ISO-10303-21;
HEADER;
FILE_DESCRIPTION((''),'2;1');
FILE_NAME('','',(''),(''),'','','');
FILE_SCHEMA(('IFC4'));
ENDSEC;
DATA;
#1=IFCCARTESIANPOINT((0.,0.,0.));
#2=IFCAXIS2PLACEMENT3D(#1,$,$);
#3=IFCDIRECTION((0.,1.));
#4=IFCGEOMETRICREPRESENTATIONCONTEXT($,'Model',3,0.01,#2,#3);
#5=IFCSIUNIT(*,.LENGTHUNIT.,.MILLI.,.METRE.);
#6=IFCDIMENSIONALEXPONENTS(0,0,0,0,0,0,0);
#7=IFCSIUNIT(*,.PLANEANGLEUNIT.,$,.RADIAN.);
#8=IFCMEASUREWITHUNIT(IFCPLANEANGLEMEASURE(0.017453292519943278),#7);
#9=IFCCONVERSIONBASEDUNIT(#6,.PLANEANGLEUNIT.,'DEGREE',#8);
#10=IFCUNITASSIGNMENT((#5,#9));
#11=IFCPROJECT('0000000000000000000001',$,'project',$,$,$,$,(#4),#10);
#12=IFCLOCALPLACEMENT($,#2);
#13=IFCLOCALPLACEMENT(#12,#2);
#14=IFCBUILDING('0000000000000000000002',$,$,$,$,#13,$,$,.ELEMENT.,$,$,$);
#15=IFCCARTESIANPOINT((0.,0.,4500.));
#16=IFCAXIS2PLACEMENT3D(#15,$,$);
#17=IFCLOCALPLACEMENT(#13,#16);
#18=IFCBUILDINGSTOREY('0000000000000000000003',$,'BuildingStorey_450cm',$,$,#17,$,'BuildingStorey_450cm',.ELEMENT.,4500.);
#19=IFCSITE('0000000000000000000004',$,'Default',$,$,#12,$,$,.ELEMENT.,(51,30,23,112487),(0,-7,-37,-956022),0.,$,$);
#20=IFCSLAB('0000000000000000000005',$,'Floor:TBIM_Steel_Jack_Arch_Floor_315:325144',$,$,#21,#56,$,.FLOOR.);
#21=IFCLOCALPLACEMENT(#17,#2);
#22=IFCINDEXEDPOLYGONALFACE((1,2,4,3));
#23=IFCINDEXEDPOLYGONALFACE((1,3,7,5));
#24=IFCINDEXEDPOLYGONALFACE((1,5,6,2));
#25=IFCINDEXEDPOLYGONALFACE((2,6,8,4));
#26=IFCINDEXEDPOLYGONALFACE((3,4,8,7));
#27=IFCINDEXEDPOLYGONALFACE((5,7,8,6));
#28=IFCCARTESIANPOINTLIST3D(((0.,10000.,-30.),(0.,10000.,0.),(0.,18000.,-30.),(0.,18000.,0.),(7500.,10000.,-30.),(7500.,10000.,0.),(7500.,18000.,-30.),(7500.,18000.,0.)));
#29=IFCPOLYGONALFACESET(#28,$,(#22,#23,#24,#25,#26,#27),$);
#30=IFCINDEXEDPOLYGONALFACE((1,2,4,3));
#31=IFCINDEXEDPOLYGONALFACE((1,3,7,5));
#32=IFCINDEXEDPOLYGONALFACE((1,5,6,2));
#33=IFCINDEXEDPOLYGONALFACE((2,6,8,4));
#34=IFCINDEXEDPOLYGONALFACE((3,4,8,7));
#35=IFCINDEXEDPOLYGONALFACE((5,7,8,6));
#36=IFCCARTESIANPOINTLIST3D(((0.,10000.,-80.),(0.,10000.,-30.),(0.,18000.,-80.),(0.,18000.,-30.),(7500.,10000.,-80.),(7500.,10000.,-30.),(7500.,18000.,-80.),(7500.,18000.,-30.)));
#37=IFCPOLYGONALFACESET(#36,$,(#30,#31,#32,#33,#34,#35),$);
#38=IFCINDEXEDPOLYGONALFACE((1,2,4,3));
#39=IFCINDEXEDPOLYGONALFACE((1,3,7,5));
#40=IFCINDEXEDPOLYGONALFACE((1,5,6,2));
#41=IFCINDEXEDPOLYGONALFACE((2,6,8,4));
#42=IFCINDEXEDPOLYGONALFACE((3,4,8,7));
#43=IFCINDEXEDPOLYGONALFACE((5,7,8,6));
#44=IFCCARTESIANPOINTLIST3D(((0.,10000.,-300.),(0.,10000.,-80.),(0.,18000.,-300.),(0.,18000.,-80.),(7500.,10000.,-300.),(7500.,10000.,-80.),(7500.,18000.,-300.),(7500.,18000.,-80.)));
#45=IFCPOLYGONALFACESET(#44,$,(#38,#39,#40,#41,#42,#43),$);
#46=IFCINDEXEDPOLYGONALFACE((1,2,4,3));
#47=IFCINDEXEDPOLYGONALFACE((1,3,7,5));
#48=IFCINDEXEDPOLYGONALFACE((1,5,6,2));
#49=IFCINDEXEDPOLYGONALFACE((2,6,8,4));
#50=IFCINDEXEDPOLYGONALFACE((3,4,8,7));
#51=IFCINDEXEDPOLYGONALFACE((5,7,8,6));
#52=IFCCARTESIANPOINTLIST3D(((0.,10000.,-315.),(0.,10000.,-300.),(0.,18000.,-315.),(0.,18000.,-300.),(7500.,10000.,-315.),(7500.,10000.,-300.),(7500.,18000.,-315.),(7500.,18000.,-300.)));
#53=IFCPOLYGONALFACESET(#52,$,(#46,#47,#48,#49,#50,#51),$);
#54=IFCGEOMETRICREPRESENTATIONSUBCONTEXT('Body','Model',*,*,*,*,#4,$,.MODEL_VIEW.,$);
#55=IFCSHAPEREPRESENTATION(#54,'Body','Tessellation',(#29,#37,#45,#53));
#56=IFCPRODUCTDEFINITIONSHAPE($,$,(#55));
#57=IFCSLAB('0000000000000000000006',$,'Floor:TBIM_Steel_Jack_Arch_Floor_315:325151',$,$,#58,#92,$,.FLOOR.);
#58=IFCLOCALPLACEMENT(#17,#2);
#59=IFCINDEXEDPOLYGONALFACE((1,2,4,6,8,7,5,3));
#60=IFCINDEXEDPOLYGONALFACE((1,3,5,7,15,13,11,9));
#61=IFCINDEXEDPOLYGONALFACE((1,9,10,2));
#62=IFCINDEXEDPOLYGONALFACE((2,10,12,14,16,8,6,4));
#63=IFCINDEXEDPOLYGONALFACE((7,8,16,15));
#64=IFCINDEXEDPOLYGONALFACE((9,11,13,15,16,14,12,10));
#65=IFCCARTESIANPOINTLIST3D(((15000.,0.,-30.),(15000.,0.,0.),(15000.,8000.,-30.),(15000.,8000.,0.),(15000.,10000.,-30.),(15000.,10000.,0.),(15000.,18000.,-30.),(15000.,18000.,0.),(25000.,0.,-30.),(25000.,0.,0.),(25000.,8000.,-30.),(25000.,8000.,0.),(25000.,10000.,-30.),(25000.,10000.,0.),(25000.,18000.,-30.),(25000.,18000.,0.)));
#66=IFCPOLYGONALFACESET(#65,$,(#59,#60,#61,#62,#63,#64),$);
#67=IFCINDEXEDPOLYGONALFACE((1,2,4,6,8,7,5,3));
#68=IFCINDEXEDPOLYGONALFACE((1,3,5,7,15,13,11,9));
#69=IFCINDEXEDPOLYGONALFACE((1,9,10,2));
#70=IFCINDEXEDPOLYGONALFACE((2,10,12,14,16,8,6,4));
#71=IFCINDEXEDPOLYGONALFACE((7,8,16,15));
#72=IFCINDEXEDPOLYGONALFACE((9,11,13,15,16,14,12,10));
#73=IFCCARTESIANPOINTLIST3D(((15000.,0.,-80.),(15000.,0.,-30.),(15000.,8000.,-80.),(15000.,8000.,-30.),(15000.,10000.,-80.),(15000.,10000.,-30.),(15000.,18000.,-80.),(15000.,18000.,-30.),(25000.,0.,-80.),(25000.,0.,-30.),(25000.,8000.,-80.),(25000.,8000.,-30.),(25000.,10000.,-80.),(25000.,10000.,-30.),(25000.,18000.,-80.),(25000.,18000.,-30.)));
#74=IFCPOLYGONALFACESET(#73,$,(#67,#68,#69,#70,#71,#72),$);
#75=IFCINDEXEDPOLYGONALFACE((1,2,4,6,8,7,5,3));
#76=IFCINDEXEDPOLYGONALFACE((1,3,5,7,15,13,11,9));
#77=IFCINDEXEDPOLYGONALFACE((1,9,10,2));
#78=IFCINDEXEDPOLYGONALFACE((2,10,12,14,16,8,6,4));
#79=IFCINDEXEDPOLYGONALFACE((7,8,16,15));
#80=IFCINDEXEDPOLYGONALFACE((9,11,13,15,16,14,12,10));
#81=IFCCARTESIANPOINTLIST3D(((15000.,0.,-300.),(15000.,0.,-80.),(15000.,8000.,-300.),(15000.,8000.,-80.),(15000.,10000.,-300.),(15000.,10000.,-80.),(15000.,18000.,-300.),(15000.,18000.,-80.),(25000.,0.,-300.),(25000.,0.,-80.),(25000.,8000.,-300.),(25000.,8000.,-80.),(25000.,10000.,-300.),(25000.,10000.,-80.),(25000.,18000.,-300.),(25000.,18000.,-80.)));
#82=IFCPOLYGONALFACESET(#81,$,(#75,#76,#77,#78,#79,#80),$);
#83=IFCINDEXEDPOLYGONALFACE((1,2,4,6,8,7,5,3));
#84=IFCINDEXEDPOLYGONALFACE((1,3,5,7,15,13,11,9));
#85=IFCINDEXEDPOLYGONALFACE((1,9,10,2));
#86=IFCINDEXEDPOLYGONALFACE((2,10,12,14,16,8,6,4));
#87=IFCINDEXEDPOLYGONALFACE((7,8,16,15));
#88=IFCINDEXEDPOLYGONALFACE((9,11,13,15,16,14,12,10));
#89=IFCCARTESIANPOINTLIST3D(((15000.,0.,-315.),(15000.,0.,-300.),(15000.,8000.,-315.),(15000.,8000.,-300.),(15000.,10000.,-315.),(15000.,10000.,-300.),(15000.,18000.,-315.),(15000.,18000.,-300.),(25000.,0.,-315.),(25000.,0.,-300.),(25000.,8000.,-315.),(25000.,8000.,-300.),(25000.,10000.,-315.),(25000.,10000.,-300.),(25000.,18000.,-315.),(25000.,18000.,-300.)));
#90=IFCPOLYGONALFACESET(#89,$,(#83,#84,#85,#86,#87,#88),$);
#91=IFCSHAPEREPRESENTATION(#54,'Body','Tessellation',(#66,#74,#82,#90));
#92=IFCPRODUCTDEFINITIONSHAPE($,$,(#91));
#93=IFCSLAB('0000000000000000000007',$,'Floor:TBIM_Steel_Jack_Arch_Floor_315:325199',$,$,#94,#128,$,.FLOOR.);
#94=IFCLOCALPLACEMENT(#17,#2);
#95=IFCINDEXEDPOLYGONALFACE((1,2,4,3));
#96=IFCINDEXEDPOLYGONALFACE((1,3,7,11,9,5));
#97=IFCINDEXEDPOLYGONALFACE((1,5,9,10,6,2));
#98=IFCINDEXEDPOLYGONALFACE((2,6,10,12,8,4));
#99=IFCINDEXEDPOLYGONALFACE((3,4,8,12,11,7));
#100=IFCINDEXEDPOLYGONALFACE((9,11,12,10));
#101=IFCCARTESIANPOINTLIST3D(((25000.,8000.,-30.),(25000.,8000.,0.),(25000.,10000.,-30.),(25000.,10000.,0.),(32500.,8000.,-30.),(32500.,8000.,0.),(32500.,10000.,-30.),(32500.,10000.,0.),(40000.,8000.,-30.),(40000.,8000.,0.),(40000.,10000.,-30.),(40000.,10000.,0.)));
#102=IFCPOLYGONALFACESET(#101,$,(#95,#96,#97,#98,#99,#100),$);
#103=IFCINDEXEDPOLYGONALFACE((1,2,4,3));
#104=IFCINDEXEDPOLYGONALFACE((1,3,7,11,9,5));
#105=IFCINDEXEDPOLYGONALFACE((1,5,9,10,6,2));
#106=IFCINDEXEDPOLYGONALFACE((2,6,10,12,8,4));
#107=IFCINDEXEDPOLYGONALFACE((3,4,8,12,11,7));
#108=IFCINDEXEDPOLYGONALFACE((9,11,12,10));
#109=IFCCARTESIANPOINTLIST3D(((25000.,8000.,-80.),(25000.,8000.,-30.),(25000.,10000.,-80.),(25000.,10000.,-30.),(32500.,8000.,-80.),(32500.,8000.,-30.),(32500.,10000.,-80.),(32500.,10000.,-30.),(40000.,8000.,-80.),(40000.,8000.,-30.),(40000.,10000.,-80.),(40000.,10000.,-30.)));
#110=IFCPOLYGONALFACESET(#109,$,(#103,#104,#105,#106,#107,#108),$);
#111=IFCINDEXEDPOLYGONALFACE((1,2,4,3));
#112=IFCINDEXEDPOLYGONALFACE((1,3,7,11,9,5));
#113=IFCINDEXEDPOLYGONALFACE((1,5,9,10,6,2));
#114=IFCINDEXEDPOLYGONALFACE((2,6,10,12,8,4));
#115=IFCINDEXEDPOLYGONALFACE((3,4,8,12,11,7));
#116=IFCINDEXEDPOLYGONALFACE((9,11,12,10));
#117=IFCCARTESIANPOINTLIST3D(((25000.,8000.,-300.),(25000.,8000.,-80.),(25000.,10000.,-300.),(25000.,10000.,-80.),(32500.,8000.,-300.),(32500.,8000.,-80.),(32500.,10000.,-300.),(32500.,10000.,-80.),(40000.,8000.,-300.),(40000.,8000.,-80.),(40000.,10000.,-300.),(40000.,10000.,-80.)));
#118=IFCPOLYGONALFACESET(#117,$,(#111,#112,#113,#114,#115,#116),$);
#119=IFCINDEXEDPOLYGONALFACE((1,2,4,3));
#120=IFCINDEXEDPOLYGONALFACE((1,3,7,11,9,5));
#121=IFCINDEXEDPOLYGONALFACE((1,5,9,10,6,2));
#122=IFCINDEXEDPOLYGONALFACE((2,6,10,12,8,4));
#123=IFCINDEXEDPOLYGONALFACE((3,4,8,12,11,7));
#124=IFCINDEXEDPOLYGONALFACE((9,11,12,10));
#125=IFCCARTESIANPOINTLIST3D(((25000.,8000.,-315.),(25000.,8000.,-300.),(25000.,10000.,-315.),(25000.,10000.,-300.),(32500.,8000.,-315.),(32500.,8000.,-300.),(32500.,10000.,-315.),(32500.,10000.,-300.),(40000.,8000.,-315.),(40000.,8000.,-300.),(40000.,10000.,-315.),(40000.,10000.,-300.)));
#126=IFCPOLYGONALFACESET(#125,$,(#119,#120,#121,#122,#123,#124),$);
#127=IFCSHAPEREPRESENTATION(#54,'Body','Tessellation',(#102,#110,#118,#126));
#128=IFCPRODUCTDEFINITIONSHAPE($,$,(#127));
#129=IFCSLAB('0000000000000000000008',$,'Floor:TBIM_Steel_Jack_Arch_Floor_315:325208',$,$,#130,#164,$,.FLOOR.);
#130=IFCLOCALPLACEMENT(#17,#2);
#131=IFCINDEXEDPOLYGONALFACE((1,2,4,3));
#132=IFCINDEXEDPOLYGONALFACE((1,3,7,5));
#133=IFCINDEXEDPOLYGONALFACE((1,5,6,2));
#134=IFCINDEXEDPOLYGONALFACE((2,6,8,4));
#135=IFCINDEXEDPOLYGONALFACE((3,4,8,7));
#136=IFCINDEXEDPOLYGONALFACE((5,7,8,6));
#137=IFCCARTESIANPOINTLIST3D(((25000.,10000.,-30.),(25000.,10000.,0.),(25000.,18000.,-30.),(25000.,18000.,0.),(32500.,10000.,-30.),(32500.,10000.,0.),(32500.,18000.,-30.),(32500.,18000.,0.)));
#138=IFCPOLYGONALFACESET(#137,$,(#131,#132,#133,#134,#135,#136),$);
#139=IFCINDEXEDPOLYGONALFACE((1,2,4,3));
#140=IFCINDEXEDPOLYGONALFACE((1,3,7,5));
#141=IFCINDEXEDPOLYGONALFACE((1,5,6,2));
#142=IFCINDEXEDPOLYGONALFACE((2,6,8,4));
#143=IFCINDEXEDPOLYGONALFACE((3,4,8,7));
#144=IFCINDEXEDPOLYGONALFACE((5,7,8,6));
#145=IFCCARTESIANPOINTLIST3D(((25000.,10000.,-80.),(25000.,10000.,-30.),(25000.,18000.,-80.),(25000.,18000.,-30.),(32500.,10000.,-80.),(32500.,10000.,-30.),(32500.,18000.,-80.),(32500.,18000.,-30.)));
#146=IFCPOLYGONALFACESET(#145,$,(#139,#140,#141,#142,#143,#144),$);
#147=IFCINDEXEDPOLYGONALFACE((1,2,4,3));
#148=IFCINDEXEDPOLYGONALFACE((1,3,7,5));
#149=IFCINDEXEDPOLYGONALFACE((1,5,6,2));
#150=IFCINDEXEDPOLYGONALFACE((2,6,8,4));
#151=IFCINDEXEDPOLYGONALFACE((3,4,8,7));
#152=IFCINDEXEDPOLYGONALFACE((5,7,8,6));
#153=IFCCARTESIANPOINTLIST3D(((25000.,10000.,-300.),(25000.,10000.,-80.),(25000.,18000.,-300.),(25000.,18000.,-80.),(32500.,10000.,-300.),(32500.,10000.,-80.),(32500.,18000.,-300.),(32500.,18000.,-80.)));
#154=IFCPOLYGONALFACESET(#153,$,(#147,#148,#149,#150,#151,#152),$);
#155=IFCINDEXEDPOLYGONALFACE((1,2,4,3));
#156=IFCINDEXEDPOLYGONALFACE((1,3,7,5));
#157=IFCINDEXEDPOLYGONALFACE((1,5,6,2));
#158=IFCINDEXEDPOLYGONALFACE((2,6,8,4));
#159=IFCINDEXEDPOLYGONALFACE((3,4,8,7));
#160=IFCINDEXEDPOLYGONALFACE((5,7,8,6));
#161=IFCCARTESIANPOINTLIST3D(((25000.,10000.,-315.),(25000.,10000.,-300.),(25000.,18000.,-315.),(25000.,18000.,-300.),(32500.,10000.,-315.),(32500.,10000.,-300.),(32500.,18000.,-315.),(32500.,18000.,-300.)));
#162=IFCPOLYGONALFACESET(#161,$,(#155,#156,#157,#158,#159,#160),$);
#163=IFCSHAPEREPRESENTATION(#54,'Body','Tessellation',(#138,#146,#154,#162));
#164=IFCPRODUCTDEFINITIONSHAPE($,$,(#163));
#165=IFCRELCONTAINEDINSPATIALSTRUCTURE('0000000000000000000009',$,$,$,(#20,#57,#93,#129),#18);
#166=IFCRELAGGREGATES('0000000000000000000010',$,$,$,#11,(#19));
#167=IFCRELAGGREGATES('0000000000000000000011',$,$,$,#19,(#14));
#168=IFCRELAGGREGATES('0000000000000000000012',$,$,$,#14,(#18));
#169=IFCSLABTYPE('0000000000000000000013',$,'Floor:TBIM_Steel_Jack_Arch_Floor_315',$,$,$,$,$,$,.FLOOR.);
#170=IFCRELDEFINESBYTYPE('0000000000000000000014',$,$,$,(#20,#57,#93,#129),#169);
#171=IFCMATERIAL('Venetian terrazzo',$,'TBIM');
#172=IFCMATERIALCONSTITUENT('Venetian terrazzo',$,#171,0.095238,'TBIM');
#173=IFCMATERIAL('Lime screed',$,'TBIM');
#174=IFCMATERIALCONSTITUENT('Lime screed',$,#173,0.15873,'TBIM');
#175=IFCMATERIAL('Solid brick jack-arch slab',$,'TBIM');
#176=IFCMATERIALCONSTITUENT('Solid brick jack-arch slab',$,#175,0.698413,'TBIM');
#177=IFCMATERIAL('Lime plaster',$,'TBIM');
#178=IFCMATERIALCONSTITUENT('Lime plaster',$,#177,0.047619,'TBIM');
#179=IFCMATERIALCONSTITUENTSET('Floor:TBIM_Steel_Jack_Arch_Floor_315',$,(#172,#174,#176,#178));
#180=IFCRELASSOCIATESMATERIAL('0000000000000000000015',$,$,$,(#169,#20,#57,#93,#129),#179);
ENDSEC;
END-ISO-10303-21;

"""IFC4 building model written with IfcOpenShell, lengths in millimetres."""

from ifc_helpers import new_model, entity, si_unit, converted_unit, direction, frame, origin, place, context, subcontext, project, spatial, indexed_curve, outline, extrude, material, constituent, constituent_set, type_object, element, save


model = new_model("IFC4")

# Units and contexts
model_context = context("Model", 3, precision=0.01, world=origin(), true_north=direction((0.0, 1.0)))
body_context = subcontext(model_context, "Body", "Model", "MODEL_VIEW")
ifc_project = project(units=[si_unit("LENGTHUNIT", "METRE", prefix="MILLI"), converted_unit("PLANEANGLEUNIT", "DEGREE", entity("IfcPlaneAngleMeasure", 0.017453292519943278), si_unit("PLANEANGLEUNIT", "RADIAN"), dimensions=[0, 0, 0, 0, 0, 0, 0])], contexts=[model_context])

# Site, building, storey
site_placement = place(None, origin())
site = spatial("IfcSite", under=ifc_project, at=site_placement, Name="Default", CompositionType="ELEMENT", RefLatitude=(51, 30, 23, 112487), RefLongitude=(0, -7, -37, -956022), RefElevation=0.0)
building_placement = place(site_placement, origin())
building = spatial("IfcBuilding", under=site, at=building_placement, CompositionType="ELEMENT")
storey_placement = place(building_placement, frame((0.0, 0.0, 4500.0)))
storey = spatial("IfcBuildingStorey", under=building, at=storey_placement, Name="BuildingStorey_450cm", LongName="BuildingStorey_450cm", CompositionType="ELEMENT", Elevation=4500.0)

# Slabs
ifc_material_1 = material(Name="Venetian terrazzo", Category="TBIM")
ifc_constituent_1 = constituent(ifc_material_1, Name="Venetian terrazzo", Category="TBIM", fraction=0.095238)
ifc_material_2 = material(Name="Lime screed", Category="TBIM")
ifc_constituent_2 = constituent(ifc_material_2, Name="Lime screed", Category="TBIM", fraction=0.15873)
ifc_material_3 = material(Name="Solid brick jack-arch slab", Category="TBIM")
ifc_constituent_3 = constituent(ifc_material_3, Name="Solid brick jack-arch slab", Category="TBIM", fraction=0.698413)
ifc_material_4 = material(Name="Lime plaster", Category="TBIM")
ifc_constituent_4 = constituent(ifc_material_4, Name="Lime plaster", Category="TBIM", fraction=0.047619)
ifc_constituent_set_1 = constituent_set(constituents=[ifc_constituent_1, ifc_constituent_2, ifc_constituent_3, ifc_constituent_4], Name="Floor:TBIM_Steel_Jack_Arch_Floor_315")
slab_type = type_object("IfcSlabType", Name="Floor:TBIM_Steel_Jack_Arch_Floor_315", PredefinedType="FLOOR", material=ifc_constituent_set_1)
slab_1_placement = place(storey_placement, origin())
element("IfcSlab", 1, at=slab_1_placement, inside=storey, type_object=slab_type, material=ifc_constituent_set_1, Name="Floor:TBIM_Steel_Jack_Arch_Floor_315:325144", PredefinedType="FLOOR", context=body_context, shape_type="SweptSolid", body=[
    extrude(outline(indexed_curve([(-3750.0, -4000.0), (3750.0, -4000.0), (3750.0, 4000.0), (-3750.0, 4000.0), (-3750.0, -4000.0)], self_intersect=False)), frame((3750.0, 14000.0, -30.0), z_axis=(0.0, 0.0, 1.0), x_axis=(-1.0, 0.0, 0.0)), (0.0, 0.0, 1.0), 30.0),
    extrude(outline(indexed_curve([(-3750.0, -4000.0), (3750.0, -4000.0), (3750.0, 4000.0), (-3750.0, 4000.0), (-3750.0, -4000.0)], self_intersect=False)), frame((3750.0, 14000.0, -80.0), z_axis=(0.0, 0.0, 1.0), x_axis=(-1.0, 0.0, 0.0)), (0.0, 0.0, 1.0), 50.0),
    extrude(outline(indexed_curve([(-3750.0, -4000.0), (3750.0, -4000.0), (3750.0, 4000.0), (-3750.0, 4000.0), (-3750.0, -4000.0)], self_intersect=False)), frame((3750.0, 14000.0, -300.0), z_axis=(0.0, 0.0, 1.0), x_axis=(-1.0, 0.0, 0.0)), (0.0, 0.0, 1.0), 220.0),
    extrude(outline(indexed_curve([(-3750.0, -4000.0), (3750.0, -4000.0), (3750.0, 4000.0), (-3750.0, 4000.0), (-3750.0, -4000.0)], self_intersect=False)), frame((3750.0, 14000.0, -315.0), z_axis=(0.0, 0.0, 1.0), x_axis=(-1.0, 0.0, 0.0)), (0.0, 0.0, 1.0), 15.0),
])
slab_2_placement = place(storey_placement, origin())
element("IfcSlab", 2, at=slab_2_placement, inside=storey, type_object=slab_type, material=ifc_constituent_set_1, Name="Floor:TBIM_Steel_Jack_Arch_Floor_315:325151", PredefinedType="FLOOR", context=body_context, shape_type="SweptSolid", body=[
    extrude(outline(indexed_curve([(-5000.0, -9000.0), (5000.0, -9000.0), (5000.0, -1000.0), (5000.0, 1000.0), (5000.0, 9000.0), (-5000.0, 9000.0), (-5000.0, 1000.0), (-5000.0, -1000.0), (-5000.0, -9000.0)], self_intersect=False)), frame((20000.0, 9000.0, -30.0), z_axis=(0.0, 0.0, 1.0), x_axis=(-1.0, 0.0, 0.0)), (0.0, 0.0, 1.0), 30.0),
    extrude(outline(indexed_curve([(-5000.0, -9000.0), (5000.0, -9000.0), (5000.0, -1000.0), (5000.0, 1000.0), (5000.0, 9000.0), (-5000.0, 9000.0), (-5000.0, 1000.0), (-5000.0, -1000.0), (-5000.0, -9000.0)], self_intersect=False)), frame((20000.0, 9000.0, -80.0), z_axis=(0.0, 0.0, 1.0), x_axis=(-1.0, 0.0, 0.0)), (0.0, 0.0, 1.0), 50.0),
    extrude(outline(indexed_curve([(-5000.0, -9000.0), (5000.0, -9000.0), (5000.0, -1000.0), (5000.0, 1000.0), (5000.0, 9000.0), (-5000.0, 9000.0), (-5000.0, 1000.0), (-5000.0, -1000.0), (-5000.0, -9000.0)], self_intersect=False)), frame((20000.0, 9000.0, -300.0), z_axis=(0.0, 0.0, 1.0), x_axis=(-1.0, 0.0, 0.0)), (0.0, 0.0, 1.0), 220.0),
    extrude(outline(indexed_curve([(-5000.0, -9000.0), (5000.0, -9000.0), (5000.0, -1000.0), (5000.0, 1000.0), (5000.0, 9000.0), (-5000.0, 9000.0), (-5000.0, 1000.0), (-5000.0, -1000.0), (-5000.0, -9000.0)], self_intersect=False)), frame((20000.0, 9000.0, -315.0), z_axis=(0.0, 0.0, 1.0), x_axis=(-1.0, 0.0, 0.0)), (0.0, 0.0, 1.0), 15.0),
])
slab_3_placement = place(storey_placement, origin())
element("IfcSlab", 3, at=slab_3_placement, inside=storey, type_object=slab_type, material=ifc_constituent_set_1, Name="Floor:TBIM_Steel_Jack_Arch_Floor_315:325199", PredefinedType="FLOOR", context=body_context, shape_type="SweptSolid", body=[
    extrude(outline(indexed_curve([(-7500.0, -1000.0), (0.0, -1000.0), (7500.0, -1000.0), (7500.0, 1000.0), (0.0, 1000.0), (-7500.0, 1000.0), (-7500.0, -1000.0)], self_intersect=False)), frame((32500.0, 9000.0, -30.0), z_axis=(0.0, 0.0, 1.0), x_axis=(-1.0, 0.0, 0.0)), (0.0, 0.0, 1.0), 30.0),
    extrude(outline(indexed_curve([(-7500.0, -1000.0), (0.0, -1000.0), (7500.0, -1000.0), (7500.0, 1000.0), (0.0, 1000.0), (-7500.0, 1000.0), (-7500.0, -1000.0)], self_intersect=False)), frame((32500.0, 9000.0, -80.0), z_axis=(0.0, 0.0, 1.0), x_axis=(-1.0, 0.0, 0.0)), (0.0, 0.0, 1.0), 50.0),
    extrude(outline(indexed_curve([(-7500.0, -1000.0), (0.0, -1000.0), (7500.0, -1000.0), (7500.0, 1000.0), (0.0, 1000.0), (-7500.0, 1000.0), (-7500.0, -1000.0)], self_intersect=False)), frame((32500.0, 9000.0, -300.0), z_axis=(0.0, 0.0, 1.0), x_axis=(-1.0, 0.0, 0.0)), (0.0, 0.0, 1.0), 220.0),
    extrude(outline(indexed_curve([(-7500.0, -1000.0), (0.0, -1000.0), (7500.0, -1000.0), (7500.0, 1000.0), (0.0, 1000.0), (-7500.0, 1000.0), (-7500.0, -1000.0)], self_intersect=False)), frame((32500.0, 9000.0, -315.0), z_axis=(0.0, 0.0, 1.0), x_axis=(-1.0, 0.0, 0.0)), (0.0, 0.0, 1.0), 15.0),
])
slab_4_placement = place(storey_placement, origin())
element("IfcSlab", 4, at=slab_4_placement, inside=storey, type_object=slab_type, material=ifc_constituent_set_1, Name="Floor:TBIM_Steel_Jack_Arch_Floor_315:325208", PredefinedType="FLOOR", context=body_context, shape_type="SweptSolid", body=[
    extrude(outline(indexed_curve([(-3750.0, -4000.0), (3750.0, -4000.0), (3750.0, 4000.0), (-3750.0, 4000.0), (-3750.0, -4000.0)], self_intersect=False)), frame((28750.0, 14000.0, -30.0), z_axis=(0.0, 0.0, 1.0), x_axis=(-1.0, 0.0, 0.0)), (0.0, 0.0, 1.0), 30.0),
    extrude(outline(indexed_curve([(-3750.0, -4000.0), (3750.0, -4000.0), (3750.0, 4000.0), (-3750.0, 4000.0), (-3750.0, -4000.0)], self_intersect=False)), frame((28750.0, 14000.0, -80.0), z_axis=(0.0, 0.0, 1.0), x_axis=(-1.0, 0.0, 0.0)), (0.0, 0.0, 1.0), 50.0),
    extrude(outline(indexed_curve([(-3750.0, -4000.0), (3750.0, -4000.0), (3750.0, 4000.0), (-3750.0, 4000.0), (-3750.0, -4000.0)], self_intersect=False)), frame((28750.0, 14000.0, -300.0), z_axis=(0.0, 0.0, 1.0), x_axis=(-1.0, 0.0, 0.0)), (0.0, 0.0, 1.0), 220.0),
    extrude(outline(indexed_curve([(-3750.0, -4000.0), (3750.0, -4000.0), (3750.0, 4000.0), (-3750.0, 4000.0), (-3750.0, -4000.0)], self_intersect=False)), frame((28750.0, 14000.0, -315.0), z_axis=(0.0, 0.0, 1.0), x_axis=(-1.0, 0.0, 0.0)), (0.0, 0.0, 1.0), 15.0),
])

save(model, "model.ifc")
